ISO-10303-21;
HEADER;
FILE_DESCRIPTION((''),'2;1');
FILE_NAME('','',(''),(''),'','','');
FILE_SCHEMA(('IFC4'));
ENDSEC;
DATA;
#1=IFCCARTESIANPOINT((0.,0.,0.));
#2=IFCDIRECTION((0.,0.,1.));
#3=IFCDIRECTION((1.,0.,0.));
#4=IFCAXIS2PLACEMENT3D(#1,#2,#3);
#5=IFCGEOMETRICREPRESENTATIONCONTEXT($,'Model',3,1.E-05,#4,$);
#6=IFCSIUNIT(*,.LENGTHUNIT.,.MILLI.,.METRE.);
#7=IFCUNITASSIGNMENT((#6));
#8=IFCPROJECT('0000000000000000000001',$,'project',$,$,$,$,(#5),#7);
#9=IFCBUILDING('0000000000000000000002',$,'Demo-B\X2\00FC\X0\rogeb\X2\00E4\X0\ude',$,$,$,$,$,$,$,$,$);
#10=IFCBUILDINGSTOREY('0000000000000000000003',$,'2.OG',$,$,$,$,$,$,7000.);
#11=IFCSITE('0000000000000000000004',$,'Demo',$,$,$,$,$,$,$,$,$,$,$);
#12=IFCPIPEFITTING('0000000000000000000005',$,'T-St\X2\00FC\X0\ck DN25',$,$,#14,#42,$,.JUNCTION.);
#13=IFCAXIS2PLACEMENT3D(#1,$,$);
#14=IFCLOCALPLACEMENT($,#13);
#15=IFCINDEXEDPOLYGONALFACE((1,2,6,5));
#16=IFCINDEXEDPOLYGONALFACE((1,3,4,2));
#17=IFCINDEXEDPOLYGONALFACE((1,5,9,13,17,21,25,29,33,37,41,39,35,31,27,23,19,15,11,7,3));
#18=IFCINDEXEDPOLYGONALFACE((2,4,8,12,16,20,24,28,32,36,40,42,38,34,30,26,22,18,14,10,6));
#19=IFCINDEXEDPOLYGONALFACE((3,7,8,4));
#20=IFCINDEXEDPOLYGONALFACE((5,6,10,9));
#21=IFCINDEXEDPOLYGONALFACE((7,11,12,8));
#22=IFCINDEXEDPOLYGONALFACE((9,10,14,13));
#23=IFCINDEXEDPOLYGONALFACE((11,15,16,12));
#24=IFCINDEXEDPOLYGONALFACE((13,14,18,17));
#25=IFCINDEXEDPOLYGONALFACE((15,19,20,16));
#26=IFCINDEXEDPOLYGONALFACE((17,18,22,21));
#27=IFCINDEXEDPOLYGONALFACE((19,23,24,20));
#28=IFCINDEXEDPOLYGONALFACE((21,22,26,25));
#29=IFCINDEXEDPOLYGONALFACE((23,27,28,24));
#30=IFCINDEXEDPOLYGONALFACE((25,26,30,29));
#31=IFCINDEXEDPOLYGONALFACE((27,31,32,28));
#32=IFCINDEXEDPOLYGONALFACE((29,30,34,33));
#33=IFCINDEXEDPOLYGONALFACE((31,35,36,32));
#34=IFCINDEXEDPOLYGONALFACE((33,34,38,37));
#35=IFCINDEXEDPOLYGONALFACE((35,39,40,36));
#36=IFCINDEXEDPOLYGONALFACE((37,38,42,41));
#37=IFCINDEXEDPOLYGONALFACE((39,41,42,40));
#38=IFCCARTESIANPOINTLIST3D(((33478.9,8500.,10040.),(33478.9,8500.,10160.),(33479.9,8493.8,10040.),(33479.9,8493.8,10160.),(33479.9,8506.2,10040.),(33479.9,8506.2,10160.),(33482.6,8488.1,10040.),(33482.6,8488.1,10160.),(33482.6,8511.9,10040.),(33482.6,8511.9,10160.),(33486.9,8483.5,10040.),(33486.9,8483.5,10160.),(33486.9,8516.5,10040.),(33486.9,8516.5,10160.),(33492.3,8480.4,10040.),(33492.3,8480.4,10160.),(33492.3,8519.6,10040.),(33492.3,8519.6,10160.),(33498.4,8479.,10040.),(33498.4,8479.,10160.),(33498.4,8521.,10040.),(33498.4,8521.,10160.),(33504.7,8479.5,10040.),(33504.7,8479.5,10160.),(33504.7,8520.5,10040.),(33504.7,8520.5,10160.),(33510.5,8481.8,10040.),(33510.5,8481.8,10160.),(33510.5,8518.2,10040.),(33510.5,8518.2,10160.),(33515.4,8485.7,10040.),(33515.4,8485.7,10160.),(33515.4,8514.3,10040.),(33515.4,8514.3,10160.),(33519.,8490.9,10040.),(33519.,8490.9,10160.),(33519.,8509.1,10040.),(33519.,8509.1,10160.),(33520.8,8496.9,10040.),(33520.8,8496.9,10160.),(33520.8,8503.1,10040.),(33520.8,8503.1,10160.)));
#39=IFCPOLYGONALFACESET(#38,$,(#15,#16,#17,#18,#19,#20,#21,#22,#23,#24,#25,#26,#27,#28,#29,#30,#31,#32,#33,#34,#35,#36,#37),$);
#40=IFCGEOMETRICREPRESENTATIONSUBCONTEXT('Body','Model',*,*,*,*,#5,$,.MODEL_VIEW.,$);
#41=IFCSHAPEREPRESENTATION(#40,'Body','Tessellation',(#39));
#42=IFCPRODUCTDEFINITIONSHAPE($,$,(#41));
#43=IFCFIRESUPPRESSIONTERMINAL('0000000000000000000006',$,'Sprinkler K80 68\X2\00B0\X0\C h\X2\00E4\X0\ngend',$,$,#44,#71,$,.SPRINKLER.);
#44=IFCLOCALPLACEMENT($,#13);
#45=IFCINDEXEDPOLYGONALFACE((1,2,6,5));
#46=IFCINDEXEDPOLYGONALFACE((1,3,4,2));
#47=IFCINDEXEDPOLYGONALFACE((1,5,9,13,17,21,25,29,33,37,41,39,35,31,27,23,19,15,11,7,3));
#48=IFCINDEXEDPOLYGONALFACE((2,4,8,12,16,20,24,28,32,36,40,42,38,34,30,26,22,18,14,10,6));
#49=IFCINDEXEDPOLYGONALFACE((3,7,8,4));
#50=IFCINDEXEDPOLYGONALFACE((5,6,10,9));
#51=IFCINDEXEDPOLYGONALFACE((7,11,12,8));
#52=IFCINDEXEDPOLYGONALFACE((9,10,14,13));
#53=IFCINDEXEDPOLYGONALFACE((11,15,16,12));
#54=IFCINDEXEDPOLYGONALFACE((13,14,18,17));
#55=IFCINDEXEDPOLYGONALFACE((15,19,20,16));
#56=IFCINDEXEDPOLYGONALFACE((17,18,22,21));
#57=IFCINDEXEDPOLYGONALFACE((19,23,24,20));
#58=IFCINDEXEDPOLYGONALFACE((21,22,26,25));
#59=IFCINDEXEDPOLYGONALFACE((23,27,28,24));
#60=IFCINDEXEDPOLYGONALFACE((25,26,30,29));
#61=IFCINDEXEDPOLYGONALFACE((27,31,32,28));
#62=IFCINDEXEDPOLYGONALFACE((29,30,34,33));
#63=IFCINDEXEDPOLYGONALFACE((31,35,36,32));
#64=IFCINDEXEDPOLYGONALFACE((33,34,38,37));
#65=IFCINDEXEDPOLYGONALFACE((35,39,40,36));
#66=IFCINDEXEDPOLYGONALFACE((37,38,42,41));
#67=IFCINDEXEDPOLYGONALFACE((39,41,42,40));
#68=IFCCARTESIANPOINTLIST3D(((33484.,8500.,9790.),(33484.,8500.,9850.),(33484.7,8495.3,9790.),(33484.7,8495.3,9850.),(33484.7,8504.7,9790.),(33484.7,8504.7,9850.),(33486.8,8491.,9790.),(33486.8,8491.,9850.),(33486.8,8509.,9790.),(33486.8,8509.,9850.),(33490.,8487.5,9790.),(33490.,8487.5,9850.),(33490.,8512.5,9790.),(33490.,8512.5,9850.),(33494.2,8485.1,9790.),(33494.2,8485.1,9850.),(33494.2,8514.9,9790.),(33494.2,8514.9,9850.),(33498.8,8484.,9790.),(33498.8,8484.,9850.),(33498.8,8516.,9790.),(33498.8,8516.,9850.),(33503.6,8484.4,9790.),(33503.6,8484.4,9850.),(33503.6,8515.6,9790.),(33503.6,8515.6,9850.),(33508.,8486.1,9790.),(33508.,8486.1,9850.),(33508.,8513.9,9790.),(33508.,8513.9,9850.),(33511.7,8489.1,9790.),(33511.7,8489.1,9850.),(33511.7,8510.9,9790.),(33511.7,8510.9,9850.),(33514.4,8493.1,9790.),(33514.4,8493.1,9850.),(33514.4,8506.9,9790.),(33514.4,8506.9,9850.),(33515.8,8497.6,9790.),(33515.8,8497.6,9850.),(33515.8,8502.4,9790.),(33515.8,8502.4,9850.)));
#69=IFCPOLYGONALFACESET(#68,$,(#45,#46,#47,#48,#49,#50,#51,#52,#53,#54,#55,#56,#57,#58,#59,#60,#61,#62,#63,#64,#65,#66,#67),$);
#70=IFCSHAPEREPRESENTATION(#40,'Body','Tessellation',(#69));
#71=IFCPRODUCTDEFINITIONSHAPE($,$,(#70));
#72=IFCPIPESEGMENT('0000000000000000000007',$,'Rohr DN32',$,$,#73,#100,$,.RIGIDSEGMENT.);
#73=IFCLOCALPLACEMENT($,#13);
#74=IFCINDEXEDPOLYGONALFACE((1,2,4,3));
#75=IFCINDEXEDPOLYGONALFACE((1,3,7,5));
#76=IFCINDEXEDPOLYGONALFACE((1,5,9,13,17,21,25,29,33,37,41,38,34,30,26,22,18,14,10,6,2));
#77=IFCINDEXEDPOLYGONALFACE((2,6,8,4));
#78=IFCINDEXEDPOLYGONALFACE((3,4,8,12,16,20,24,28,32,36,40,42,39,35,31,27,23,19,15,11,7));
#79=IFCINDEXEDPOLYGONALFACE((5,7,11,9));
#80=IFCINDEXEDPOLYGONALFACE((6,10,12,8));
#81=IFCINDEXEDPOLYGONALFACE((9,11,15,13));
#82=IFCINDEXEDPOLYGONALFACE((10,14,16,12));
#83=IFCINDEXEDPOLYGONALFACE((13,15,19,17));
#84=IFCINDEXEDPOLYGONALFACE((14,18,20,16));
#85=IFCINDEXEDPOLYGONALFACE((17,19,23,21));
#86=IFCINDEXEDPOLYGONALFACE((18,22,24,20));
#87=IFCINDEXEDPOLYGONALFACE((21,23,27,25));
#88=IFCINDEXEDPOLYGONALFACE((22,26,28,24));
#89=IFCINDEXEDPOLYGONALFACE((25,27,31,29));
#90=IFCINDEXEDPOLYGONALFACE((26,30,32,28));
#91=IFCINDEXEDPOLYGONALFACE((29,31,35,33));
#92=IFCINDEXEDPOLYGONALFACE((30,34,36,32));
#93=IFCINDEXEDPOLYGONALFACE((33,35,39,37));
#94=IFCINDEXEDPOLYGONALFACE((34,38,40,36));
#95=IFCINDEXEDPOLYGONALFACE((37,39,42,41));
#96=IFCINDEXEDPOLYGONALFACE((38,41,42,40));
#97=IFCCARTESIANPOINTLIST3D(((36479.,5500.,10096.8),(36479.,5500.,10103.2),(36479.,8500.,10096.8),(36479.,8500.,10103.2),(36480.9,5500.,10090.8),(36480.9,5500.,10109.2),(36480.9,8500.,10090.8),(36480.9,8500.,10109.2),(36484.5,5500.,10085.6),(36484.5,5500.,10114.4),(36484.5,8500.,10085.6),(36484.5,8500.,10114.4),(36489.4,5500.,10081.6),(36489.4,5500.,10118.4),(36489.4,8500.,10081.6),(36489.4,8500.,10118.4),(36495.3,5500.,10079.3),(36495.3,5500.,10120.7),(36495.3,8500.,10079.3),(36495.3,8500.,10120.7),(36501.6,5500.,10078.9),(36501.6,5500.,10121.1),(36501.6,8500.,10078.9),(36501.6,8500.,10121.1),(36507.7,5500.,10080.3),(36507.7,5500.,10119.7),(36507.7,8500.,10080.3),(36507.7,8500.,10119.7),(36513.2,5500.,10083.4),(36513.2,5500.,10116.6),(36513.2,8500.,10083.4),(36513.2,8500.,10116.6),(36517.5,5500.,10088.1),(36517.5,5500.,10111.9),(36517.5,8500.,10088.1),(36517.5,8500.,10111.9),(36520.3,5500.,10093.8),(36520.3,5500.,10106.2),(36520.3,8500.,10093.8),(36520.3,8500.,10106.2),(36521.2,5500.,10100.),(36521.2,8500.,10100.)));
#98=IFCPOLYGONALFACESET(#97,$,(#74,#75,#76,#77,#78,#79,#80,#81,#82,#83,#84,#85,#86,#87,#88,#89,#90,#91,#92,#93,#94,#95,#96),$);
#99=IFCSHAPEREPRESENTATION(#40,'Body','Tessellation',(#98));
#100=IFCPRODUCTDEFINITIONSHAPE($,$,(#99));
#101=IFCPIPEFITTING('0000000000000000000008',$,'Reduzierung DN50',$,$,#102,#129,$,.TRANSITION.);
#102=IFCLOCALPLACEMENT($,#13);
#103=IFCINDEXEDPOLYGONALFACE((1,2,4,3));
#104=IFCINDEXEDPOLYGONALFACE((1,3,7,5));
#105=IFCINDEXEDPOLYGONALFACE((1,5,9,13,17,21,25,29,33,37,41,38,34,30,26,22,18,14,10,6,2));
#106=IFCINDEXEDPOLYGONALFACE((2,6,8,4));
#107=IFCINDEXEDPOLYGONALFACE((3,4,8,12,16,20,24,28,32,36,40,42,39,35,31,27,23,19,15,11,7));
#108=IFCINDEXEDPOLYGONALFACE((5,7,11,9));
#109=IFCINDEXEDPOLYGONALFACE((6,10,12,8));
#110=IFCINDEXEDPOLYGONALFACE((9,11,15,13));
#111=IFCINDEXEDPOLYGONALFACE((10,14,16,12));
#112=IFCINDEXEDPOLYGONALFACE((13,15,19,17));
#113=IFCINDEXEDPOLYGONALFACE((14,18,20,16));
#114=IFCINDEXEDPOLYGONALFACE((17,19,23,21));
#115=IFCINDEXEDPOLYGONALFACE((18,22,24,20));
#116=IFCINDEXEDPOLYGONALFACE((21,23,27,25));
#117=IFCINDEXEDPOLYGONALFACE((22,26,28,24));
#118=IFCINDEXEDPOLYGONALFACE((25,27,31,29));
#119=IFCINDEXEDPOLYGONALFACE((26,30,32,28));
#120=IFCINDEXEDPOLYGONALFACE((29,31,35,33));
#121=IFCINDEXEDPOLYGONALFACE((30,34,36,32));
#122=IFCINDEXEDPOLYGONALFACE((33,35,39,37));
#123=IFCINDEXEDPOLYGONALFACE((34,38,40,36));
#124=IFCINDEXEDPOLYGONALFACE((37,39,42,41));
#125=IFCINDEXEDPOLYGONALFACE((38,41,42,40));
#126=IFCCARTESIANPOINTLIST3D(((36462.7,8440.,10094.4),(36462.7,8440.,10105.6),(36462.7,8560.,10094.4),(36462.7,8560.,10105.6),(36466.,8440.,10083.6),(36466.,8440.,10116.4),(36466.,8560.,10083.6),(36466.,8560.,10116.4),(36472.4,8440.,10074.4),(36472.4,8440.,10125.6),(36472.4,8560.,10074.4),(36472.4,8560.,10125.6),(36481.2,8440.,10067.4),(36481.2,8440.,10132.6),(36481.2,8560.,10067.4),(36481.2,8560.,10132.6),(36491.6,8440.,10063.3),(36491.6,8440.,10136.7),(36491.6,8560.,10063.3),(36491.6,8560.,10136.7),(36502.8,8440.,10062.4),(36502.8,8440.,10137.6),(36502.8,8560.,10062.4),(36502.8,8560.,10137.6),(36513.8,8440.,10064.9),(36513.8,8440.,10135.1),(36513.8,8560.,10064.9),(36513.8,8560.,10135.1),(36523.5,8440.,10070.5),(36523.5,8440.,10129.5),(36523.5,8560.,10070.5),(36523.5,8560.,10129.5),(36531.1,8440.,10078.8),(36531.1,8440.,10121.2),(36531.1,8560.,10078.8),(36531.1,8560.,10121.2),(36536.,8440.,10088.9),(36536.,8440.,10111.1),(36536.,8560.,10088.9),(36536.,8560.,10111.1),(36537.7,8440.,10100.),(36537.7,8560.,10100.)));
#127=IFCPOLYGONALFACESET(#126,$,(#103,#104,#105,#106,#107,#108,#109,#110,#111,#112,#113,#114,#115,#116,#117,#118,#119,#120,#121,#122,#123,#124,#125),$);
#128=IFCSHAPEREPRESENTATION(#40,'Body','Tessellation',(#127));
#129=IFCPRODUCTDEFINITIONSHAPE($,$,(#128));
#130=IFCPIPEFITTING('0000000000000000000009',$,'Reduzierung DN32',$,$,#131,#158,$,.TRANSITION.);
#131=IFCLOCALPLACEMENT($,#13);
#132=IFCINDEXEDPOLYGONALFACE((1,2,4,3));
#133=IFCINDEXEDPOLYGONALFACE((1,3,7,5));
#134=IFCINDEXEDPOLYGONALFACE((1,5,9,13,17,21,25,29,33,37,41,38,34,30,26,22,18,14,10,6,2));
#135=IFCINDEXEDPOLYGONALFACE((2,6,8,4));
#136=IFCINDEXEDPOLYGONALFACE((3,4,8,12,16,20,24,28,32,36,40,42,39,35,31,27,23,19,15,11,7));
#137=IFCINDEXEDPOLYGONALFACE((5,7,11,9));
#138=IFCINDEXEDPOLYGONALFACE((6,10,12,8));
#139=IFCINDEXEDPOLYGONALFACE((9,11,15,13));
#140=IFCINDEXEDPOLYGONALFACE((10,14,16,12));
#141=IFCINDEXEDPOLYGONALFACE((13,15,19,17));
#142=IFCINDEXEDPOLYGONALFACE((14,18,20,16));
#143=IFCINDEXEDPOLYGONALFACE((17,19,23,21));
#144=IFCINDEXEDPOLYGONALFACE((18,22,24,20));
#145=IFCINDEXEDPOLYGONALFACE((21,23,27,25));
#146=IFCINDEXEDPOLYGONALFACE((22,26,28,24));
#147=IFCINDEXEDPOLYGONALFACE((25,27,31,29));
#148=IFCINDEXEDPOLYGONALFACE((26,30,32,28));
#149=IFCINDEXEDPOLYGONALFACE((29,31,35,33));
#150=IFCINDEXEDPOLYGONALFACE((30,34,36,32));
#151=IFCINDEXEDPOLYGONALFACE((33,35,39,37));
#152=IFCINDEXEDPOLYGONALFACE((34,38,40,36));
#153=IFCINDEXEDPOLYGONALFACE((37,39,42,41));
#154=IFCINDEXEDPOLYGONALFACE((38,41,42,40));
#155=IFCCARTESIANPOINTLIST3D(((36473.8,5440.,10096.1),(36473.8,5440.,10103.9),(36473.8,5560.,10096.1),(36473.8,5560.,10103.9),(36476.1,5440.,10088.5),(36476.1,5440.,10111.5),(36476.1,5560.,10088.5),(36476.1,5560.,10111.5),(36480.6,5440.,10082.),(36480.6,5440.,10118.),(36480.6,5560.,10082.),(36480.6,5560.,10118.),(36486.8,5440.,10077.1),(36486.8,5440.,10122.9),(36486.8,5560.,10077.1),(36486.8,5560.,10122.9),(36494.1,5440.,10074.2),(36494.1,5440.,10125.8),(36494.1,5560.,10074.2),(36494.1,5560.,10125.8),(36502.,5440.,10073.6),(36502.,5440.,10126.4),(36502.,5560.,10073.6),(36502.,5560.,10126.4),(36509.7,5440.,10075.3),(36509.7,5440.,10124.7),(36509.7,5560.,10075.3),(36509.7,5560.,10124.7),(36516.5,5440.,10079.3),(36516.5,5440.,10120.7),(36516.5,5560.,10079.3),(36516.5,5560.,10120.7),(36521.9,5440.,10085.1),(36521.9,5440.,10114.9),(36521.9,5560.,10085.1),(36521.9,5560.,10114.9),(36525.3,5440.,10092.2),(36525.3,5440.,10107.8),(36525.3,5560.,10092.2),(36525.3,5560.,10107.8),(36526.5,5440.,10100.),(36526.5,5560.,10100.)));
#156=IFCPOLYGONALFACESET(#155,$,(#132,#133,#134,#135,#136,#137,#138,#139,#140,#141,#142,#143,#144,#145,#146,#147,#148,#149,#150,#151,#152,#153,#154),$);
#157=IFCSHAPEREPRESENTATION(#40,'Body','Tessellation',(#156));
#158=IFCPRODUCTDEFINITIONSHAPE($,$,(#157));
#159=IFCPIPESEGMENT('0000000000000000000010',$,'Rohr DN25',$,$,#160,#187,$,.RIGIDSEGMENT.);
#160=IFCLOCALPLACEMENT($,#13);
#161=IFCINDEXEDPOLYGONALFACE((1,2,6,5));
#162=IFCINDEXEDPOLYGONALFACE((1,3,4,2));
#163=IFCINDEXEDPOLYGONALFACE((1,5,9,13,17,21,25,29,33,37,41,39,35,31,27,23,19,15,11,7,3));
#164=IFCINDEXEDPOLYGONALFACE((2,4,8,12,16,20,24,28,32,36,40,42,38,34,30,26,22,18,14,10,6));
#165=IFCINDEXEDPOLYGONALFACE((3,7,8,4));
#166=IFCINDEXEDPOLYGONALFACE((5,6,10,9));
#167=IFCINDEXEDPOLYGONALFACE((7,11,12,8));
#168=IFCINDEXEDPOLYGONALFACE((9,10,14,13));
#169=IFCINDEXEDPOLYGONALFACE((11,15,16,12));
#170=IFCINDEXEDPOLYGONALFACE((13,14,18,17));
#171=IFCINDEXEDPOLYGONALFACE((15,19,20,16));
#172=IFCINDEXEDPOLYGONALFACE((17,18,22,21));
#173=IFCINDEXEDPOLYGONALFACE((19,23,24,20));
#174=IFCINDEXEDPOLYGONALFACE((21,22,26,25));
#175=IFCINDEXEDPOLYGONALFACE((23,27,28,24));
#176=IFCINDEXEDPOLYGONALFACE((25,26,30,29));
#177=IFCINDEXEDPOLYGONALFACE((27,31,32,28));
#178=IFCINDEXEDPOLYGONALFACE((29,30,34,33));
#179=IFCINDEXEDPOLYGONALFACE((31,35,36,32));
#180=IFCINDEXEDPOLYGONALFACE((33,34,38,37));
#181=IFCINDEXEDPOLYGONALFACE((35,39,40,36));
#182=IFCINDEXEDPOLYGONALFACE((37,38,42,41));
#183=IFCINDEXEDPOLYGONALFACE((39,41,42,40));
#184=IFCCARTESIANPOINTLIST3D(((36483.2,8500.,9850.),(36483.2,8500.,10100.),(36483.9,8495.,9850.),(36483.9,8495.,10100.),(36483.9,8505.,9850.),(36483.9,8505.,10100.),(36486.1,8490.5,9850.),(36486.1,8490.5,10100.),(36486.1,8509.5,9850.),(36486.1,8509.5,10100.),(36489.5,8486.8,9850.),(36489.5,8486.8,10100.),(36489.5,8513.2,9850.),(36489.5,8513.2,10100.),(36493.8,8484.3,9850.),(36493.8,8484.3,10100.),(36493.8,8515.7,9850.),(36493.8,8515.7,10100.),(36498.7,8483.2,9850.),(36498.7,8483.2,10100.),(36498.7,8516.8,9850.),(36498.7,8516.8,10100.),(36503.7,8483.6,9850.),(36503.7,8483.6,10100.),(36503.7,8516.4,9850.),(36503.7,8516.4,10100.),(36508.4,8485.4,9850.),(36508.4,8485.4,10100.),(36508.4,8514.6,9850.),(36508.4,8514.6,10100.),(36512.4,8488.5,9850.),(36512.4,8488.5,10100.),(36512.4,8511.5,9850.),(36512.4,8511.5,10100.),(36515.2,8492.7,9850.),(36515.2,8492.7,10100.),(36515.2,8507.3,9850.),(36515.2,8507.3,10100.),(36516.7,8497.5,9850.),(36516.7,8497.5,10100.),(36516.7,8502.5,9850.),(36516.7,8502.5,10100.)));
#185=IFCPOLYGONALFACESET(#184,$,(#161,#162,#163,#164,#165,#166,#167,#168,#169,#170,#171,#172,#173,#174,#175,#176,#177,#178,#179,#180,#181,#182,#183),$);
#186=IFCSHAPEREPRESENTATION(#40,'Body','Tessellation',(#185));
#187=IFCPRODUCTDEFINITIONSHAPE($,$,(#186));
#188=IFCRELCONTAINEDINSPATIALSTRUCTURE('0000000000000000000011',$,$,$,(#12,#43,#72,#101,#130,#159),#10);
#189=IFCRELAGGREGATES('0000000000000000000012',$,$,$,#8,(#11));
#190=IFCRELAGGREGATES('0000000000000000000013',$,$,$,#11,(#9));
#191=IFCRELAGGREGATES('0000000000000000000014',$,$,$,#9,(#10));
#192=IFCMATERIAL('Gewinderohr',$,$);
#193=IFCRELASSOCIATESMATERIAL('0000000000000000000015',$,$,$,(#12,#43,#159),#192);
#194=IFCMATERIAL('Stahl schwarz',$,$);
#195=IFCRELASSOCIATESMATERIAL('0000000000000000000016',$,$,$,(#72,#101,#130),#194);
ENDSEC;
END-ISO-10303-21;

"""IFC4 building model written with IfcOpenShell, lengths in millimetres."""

from ifc_helpers import new_model, si_unit, frame, origin_with_axes, place, context, subcontext, project, spatial, circle, extrude, material, element, save


model = new_model("IFC4")

# Units and contexts
model_context = context("Model", 3, precision=1e-05, world=origin_with_axes())
body_context = subcontext(model_context, "Body", "Model", "MODEL_VIEW")
ifc_project = project(units=[si_unit("LENGTHUNIT", "METRE", prefix="MILLI")], contexts=[model_context])

# Site, building, storey
site = spatial("IfcSite", under=ifc_project, Name="Demo")
building = spatial("IfcBuilding", under=site, Name="Demo-Bürogebäude")
storey = spatial("IfcBuildingStorey", under=building, Name="2.OG", Elevation=7000.0)

# Shared definitions
ifc_material_1 = material(Name="Stahl schwarz")

# Shared definitions
ifc_material_2 = material(Name="Gewinderohr")

# Pipe fitting
pipe_fitting_1_placement = place(None, frame((33500.0, 8500.0, 10160.0), z_axis=(0.0, 0.0, -1.0), x_axis=(-1.0, 0.0, 0.0)))
element("IfcPipeFitting", 1, at=pipe_fitting_1_placement, inside=storey, material=ifc_material_2, Name="T-Stück DN25", PredefinedType="JUNCTION", context=body_context, shape_type="SweptSolid", body=[
    extrude(circle(Radius=21.1), origin_with_axes(), (0.0, 0.0, 1.0), 120.0),
])

# Fire suppression terminal
fire_suppression_terminal_1_placement = place(None, frame((33500.0, 8500.0, 9850.0), z_axis=(0.0, 0.0, -1.0), x_axis=(-1.0, 0.0, 0.0)))
element("IfcFireSuppressionTerminal", 2, at=fire_suppression_terminal_1_placement, inside=storey, material=ifc_material_2, Name="Sprinkler K80 68°C hängend", PredefinedType="SPRINKLER", context=body_context, shape_type="SweptSolid", body=[
    extrude(circle(Radius=16.0), origin_with_axes(), (0.0, 0.0, 1.0), 60.0),
])

# Pipe segment
pipe_segment_1_placement = place(None, frame((36500.0, 8500.0, 10100.0), z_axis=(0.0, -1.0, 0.0), x_axis=(1.0, 0.0, 0.0)))
element("IfcPipeSegment", 3, at=pipe_segment_1_placement, inside=storey, material=ifc_material_1, Name="Rohr DN32", PredefinedType="RIGIDSEGMENT", context=body_context, shape_type="SweptSolid", body=[
    extrude(circle(Radius=21.2), origin_with_axes(), (0.0, 0.0, 1.0), 3000.0),
])

# Pipe fittings
pipe_fitting_2_placement = place(None, frame((36500.0, 8560.0, 10100.0), z_axis=(0.0, -1.0, 0.0), x_axis=(1.0, 0.0, 0.0)))
element("IfcPipeFitting", 4, at=pipe_fitting_2_placement, inside=storey, material=ifc_material_1, Name="Reduzierung DN50", PredefinedType="TRANSITION", context=body_context, shape_type="SweptSolid", body=[
    extrude(circle(Radius=37.7), origin_with_axes(), (0.0, 0.0, 1.0), 120.0),
])
pipe_fitting_3_placement = place(None, frame((36500.0, 5560.0, 10100.0), z_axis=(0.0, -1.0, 0.0), x_axis=(1.0, 0.0, 0.0)))
element("IfcPipeFitting", 5, at=pipe_fitting_3_placement, inside=storey, material=ifc_material_1, Name="Reduzierung DN32", PredefinedType="TRANSITION", context=body_context, shape_type="SweptSolid", body=[
    extrude(circle(Radius=26.5), origin_with_axes(), (0.0, 0.0, 1.0), 120.0),
])

# Pipe segment
pipe_segment_2_placement = place(None, frame((36500.0, 8500.0, 10100.0), z_axis=(0.0, 0.0, -1.0), x_axis=(-1.0, 0.0, 0.0)))
element("IfcPipeSegment", 6, at=pipe_segment_2_placement, inside=storey, material=ifc_material_2, Name="Rohr DN25", PredefinedType="RIGIDSEGMENT", context=body_context, shape_type="SweptSolid", body=[
    extrude(circle(Radius=16.9), origin_with_axes(), (0.0, 0.0, 1.0), 250.0),
])

save(model, "model.ifc")
